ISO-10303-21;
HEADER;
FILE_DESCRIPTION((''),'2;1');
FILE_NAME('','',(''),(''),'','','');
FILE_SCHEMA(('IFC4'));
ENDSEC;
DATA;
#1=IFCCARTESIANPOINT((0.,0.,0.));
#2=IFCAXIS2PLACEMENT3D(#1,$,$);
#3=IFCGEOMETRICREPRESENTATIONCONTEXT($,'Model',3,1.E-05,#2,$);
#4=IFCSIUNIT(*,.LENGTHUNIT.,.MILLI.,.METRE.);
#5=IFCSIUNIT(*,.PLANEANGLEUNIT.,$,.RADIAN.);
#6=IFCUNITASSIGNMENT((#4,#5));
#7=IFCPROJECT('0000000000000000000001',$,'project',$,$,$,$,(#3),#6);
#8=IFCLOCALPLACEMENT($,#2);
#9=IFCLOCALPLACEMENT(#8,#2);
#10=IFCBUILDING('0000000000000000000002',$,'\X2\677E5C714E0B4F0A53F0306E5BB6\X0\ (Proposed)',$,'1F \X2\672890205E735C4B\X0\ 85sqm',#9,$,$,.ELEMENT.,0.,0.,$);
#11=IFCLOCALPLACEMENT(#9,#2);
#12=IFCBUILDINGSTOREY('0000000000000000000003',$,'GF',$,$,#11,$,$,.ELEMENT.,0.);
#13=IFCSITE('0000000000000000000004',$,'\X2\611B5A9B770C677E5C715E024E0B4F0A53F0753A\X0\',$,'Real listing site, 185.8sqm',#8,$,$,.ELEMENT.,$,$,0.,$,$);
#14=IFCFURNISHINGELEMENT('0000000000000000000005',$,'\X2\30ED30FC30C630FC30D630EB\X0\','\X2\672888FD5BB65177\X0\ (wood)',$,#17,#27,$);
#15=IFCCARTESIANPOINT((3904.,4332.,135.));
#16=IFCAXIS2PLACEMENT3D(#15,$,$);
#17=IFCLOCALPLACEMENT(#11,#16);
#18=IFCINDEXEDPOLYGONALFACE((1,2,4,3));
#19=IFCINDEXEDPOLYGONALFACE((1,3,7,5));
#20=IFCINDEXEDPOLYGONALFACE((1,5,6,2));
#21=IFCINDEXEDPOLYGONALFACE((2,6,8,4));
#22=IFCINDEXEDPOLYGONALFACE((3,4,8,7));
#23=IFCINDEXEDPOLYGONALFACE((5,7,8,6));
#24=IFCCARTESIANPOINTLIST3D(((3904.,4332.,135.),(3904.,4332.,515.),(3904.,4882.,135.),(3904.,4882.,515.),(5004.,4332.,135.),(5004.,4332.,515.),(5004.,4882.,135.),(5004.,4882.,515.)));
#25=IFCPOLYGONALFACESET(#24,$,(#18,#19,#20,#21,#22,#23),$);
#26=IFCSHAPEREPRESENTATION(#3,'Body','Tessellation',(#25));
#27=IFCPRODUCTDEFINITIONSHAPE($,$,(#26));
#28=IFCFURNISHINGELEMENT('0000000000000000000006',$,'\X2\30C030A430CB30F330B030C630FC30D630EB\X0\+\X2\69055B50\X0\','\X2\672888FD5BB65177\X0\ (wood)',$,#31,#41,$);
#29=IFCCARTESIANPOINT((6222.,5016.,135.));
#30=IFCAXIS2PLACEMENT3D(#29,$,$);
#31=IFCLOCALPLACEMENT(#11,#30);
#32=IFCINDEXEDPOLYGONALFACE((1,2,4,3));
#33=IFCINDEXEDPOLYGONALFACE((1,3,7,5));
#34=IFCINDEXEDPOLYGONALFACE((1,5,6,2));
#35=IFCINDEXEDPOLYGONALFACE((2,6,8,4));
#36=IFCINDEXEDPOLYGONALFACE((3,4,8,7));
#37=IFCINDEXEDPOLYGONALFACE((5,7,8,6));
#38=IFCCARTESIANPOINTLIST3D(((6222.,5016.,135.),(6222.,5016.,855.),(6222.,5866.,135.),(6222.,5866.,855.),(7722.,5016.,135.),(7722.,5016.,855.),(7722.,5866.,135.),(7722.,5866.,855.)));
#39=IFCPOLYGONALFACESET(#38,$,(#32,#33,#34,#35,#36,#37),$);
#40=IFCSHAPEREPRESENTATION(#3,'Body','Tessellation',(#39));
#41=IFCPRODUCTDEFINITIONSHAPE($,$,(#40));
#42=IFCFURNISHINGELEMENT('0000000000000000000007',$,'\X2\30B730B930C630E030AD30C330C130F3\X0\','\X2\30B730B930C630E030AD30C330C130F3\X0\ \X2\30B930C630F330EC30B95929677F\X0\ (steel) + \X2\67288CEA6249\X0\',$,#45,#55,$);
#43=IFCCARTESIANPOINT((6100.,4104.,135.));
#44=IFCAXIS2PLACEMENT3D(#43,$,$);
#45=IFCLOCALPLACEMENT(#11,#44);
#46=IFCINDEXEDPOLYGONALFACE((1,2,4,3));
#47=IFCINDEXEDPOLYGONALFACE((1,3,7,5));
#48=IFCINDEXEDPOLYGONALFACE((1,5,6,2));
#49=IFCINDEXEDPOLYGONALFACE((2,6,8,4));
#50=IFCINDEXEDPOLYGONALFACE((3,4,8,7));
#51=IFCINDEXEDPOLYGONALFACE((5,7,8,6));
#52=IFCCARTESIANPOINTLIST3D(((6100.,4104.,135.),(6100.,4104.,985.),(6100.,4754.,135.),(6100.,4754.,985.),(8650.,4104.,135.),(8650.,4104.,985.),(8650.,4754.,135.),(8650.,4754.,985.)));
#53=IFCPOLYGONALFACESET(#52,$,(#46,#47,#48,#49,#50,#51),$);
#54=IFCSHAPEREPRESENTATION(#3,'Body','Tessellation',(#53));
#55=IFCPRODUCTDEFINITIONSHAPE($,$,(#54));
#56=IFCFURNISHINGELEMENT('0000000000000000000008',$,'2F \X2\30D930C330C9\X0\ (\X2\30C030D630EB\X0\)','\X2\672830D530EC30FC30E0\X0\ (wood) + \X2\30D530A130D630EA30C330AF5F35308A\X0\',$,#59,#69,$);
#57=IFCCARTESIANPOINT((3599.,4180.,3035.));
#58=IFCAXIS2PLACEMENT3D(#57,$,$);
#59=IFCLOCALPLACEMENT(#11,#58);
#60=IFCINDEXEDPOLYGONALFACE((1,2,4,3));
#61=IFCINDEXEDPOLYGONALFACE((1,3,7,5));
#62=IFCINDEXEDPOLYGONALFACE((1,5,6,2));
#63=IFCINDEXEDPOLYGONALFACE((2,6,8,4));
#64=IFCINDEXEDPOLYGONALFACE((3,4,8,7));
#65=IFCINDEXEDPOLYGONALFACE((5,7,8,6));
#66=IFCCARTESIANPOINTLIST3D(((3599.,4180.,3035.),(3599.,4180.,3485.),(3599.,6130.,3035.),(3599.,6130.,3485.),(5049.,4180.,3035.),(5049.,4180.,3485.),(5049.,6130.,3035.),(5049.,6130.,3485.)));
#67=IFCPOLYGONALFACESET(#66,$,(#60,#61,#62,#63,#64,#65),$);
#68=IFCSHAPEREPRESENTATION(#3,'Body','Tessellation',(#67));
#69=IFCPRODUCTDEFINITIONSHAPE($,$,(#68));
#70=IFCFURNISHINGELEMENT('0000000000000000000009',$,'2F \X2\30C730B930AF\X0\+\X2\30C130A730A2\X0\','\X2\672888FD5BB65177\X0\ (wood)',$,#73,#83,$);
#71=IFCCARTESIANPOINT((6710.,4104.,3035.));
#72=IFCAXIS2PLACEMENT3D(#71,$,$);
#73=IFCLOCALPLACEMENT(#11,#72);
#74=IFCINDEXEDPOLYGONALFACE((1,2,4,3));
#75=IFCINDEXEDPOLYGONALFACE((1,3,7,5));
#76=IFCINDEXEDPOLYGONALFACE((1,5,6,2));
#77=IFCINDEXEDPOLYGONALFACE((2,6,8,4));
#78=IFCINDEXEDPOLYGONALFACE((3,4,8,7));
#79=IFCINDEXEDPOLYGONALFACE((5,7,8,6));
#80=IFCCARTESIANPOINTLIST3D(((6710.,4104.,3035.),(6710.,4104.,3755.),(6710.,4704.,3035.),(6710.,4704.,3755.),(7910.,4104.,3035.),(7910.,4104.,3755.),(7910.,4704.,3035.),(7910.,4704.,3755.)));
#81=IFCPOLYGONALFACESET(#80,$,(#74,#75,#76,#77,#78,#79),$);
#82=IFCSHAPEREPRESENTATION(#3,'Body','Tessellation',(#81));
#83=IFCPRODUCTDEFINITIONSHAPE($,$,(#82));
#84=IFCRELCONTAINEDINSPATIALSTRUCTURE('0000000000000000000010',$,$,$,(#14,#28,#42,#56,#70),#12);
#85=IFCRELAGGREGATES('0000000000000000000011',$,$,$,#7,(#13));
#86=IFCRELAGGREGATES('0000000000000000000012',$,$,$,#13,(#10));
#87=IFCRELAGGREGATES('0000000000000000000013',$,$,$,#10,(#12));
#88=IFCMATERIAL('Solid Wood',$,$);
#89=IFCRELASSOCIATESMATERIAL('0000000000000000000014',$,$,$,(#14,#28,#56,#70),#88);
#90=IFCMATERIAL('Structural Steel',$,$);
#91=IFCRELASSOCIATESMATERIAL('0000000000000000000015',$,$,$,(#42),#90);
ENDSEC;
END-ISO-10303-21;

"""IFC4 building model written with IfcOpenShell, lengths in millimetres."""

from ifc_helpers import new_model, si_unit, frame, frame_2d, origin, place, context, project, spatial, rectangle, extrude, material, element, save


model = new_model("IFC4")

# Units and contexts
model_context = context("Model", 3, precision=1e-05, world=origin())
ifc_project = project(units=[si_unit("LENGTHUNIT", "METRE", prefix="MILLI"), si_unit("PLANEANGLEUNIT", "RADIAN")], contexts=[model_context])

# Site, building, storey
site_placement = place(None, origin())
site = spatial("IfcSite", under=ifc_project, at=site_placement, Name="愛媛県松山市下伊台町", ObjectType="Real listing site, 185.8sqm", CompositionType="ELEMENT", RefElevation=0.0)
building_placement = place(site_placement, origin())
building = spatial("IfcBuilding", under=site, at=building_placement, Name="松山下伊台の家 (Proposed)", ObjectType="1F 木造平屋 85sqm", CompositionType="ELEMENT", ElevationOfRefHeight=0.0, ElevationOfTerrain=0.0)
storey_placement = place(building_placement, origin())
storey = spatial("IfcBuildingStorey", under=building, at=storey_placement, Name="GF", CompositionType="ELEMENT", Elevation=0.0)

# Shared definitions
ifc_material_1 = material(Name="Solid Wood")

# Shared definitions
ifc_material_2 = material(Name="Structural Steel")

# Furnishing elements
furnishing_1_placement = place(storey_placement, frame((3904.0, 4332.0, 135.0)))
element("IfcFurnishingElement", 1, at=furnishing_1_placement, inside=storey, material=ifc_material_1, Name="ローテーブル", Description="木製家具 (wood)", context=model_context, shape_type="SweptSolid", body=[
    extrude(rectangle(XDim=1100.0, YDim=550.0, at=frame_2d((550.0, 275.0))), frame((3904.0, 4332.0, 135.0)), (0.0, 0.0, 1.0), 380.0),
])
furnishing_2_placement = place(storey_placement, frame((6222.0, 5016.0, 135.0)))
element("IfcFurnishingElement", 2, at=furnishing_2_placement, inside=storey, material=ifc_material_1, Name="ダイニングテーブル+椅子", Description="木製家具 (wood)", context=model_context, shape_type="SweptSolid", body=[
    extrude(rectangle(XDim=1500.0, YDim=850.0, at=frame_2d((750.0, 425.0))), frame((6222.0, 5016.0, 135.0)), (0.0, 0.0, 1.0), 720.0),
])
furnishing_3_placement = place(storey_placement, frame((6100.0, 4104.0, 135.0)))
element("IfcFurnishingElement", 3, at=furnishing_3_placement, inside=storey, material=ifc_material_2, Name="システムキッチン", Description="システムキッチン ステンレス天板 (steel) + 木質扉", context=model_context, shape_type="SweptSolid", body=[
    extrude(rectangle(XDim=2550.0, YDim=650.0, at=frame_2d((1275.0, 325.0))), frame((6100.0, 4104.0, 135.0)), (0.0, 0.0, 1.0), 850.0),
])
furnishing_4_placement = place(storey_placement, frame((3599.0, 4180.0, 3035.0)))
element("IfcFurnishingElement", 4, at=furnishing_4_placement, inside=storey, material=ifc_material_1, Name="2F ベッド (ダブル)", Description="木フレーム (wood) + ファブリック張り", context=model_context, shape_type="SweptSolid", body=[
    extrude(rectangle(XDim=1450.0, YDim=1950.0, at=frame_2d((725.0, 975.0))), frame((3599.0, 4180.0, 3035.0)), (0.0, 0.0, 1.0), 450.0),
])
furnishing_5_placement = place(storey_placement, frame((6710.0, 4104.0, 3035.0)))
element("IfcFurnishingElement", 5, at=furnishing_5_placement, inside=storey, material=ifc_material_1, Name="2F デスク+チェア", Description="木製家具 (wood)", context=model_context, shape_type="SweptSolid", body=[
    extrude(rectangle(XDim=1200.0, YDim=600.0, at=frame_2d((600.0, 300.0))), frame((6710.0, 4104.0, 3035.0)), (0.0, 0.0, 1.0), 720.0),
])

save(model, "model.ifc")
